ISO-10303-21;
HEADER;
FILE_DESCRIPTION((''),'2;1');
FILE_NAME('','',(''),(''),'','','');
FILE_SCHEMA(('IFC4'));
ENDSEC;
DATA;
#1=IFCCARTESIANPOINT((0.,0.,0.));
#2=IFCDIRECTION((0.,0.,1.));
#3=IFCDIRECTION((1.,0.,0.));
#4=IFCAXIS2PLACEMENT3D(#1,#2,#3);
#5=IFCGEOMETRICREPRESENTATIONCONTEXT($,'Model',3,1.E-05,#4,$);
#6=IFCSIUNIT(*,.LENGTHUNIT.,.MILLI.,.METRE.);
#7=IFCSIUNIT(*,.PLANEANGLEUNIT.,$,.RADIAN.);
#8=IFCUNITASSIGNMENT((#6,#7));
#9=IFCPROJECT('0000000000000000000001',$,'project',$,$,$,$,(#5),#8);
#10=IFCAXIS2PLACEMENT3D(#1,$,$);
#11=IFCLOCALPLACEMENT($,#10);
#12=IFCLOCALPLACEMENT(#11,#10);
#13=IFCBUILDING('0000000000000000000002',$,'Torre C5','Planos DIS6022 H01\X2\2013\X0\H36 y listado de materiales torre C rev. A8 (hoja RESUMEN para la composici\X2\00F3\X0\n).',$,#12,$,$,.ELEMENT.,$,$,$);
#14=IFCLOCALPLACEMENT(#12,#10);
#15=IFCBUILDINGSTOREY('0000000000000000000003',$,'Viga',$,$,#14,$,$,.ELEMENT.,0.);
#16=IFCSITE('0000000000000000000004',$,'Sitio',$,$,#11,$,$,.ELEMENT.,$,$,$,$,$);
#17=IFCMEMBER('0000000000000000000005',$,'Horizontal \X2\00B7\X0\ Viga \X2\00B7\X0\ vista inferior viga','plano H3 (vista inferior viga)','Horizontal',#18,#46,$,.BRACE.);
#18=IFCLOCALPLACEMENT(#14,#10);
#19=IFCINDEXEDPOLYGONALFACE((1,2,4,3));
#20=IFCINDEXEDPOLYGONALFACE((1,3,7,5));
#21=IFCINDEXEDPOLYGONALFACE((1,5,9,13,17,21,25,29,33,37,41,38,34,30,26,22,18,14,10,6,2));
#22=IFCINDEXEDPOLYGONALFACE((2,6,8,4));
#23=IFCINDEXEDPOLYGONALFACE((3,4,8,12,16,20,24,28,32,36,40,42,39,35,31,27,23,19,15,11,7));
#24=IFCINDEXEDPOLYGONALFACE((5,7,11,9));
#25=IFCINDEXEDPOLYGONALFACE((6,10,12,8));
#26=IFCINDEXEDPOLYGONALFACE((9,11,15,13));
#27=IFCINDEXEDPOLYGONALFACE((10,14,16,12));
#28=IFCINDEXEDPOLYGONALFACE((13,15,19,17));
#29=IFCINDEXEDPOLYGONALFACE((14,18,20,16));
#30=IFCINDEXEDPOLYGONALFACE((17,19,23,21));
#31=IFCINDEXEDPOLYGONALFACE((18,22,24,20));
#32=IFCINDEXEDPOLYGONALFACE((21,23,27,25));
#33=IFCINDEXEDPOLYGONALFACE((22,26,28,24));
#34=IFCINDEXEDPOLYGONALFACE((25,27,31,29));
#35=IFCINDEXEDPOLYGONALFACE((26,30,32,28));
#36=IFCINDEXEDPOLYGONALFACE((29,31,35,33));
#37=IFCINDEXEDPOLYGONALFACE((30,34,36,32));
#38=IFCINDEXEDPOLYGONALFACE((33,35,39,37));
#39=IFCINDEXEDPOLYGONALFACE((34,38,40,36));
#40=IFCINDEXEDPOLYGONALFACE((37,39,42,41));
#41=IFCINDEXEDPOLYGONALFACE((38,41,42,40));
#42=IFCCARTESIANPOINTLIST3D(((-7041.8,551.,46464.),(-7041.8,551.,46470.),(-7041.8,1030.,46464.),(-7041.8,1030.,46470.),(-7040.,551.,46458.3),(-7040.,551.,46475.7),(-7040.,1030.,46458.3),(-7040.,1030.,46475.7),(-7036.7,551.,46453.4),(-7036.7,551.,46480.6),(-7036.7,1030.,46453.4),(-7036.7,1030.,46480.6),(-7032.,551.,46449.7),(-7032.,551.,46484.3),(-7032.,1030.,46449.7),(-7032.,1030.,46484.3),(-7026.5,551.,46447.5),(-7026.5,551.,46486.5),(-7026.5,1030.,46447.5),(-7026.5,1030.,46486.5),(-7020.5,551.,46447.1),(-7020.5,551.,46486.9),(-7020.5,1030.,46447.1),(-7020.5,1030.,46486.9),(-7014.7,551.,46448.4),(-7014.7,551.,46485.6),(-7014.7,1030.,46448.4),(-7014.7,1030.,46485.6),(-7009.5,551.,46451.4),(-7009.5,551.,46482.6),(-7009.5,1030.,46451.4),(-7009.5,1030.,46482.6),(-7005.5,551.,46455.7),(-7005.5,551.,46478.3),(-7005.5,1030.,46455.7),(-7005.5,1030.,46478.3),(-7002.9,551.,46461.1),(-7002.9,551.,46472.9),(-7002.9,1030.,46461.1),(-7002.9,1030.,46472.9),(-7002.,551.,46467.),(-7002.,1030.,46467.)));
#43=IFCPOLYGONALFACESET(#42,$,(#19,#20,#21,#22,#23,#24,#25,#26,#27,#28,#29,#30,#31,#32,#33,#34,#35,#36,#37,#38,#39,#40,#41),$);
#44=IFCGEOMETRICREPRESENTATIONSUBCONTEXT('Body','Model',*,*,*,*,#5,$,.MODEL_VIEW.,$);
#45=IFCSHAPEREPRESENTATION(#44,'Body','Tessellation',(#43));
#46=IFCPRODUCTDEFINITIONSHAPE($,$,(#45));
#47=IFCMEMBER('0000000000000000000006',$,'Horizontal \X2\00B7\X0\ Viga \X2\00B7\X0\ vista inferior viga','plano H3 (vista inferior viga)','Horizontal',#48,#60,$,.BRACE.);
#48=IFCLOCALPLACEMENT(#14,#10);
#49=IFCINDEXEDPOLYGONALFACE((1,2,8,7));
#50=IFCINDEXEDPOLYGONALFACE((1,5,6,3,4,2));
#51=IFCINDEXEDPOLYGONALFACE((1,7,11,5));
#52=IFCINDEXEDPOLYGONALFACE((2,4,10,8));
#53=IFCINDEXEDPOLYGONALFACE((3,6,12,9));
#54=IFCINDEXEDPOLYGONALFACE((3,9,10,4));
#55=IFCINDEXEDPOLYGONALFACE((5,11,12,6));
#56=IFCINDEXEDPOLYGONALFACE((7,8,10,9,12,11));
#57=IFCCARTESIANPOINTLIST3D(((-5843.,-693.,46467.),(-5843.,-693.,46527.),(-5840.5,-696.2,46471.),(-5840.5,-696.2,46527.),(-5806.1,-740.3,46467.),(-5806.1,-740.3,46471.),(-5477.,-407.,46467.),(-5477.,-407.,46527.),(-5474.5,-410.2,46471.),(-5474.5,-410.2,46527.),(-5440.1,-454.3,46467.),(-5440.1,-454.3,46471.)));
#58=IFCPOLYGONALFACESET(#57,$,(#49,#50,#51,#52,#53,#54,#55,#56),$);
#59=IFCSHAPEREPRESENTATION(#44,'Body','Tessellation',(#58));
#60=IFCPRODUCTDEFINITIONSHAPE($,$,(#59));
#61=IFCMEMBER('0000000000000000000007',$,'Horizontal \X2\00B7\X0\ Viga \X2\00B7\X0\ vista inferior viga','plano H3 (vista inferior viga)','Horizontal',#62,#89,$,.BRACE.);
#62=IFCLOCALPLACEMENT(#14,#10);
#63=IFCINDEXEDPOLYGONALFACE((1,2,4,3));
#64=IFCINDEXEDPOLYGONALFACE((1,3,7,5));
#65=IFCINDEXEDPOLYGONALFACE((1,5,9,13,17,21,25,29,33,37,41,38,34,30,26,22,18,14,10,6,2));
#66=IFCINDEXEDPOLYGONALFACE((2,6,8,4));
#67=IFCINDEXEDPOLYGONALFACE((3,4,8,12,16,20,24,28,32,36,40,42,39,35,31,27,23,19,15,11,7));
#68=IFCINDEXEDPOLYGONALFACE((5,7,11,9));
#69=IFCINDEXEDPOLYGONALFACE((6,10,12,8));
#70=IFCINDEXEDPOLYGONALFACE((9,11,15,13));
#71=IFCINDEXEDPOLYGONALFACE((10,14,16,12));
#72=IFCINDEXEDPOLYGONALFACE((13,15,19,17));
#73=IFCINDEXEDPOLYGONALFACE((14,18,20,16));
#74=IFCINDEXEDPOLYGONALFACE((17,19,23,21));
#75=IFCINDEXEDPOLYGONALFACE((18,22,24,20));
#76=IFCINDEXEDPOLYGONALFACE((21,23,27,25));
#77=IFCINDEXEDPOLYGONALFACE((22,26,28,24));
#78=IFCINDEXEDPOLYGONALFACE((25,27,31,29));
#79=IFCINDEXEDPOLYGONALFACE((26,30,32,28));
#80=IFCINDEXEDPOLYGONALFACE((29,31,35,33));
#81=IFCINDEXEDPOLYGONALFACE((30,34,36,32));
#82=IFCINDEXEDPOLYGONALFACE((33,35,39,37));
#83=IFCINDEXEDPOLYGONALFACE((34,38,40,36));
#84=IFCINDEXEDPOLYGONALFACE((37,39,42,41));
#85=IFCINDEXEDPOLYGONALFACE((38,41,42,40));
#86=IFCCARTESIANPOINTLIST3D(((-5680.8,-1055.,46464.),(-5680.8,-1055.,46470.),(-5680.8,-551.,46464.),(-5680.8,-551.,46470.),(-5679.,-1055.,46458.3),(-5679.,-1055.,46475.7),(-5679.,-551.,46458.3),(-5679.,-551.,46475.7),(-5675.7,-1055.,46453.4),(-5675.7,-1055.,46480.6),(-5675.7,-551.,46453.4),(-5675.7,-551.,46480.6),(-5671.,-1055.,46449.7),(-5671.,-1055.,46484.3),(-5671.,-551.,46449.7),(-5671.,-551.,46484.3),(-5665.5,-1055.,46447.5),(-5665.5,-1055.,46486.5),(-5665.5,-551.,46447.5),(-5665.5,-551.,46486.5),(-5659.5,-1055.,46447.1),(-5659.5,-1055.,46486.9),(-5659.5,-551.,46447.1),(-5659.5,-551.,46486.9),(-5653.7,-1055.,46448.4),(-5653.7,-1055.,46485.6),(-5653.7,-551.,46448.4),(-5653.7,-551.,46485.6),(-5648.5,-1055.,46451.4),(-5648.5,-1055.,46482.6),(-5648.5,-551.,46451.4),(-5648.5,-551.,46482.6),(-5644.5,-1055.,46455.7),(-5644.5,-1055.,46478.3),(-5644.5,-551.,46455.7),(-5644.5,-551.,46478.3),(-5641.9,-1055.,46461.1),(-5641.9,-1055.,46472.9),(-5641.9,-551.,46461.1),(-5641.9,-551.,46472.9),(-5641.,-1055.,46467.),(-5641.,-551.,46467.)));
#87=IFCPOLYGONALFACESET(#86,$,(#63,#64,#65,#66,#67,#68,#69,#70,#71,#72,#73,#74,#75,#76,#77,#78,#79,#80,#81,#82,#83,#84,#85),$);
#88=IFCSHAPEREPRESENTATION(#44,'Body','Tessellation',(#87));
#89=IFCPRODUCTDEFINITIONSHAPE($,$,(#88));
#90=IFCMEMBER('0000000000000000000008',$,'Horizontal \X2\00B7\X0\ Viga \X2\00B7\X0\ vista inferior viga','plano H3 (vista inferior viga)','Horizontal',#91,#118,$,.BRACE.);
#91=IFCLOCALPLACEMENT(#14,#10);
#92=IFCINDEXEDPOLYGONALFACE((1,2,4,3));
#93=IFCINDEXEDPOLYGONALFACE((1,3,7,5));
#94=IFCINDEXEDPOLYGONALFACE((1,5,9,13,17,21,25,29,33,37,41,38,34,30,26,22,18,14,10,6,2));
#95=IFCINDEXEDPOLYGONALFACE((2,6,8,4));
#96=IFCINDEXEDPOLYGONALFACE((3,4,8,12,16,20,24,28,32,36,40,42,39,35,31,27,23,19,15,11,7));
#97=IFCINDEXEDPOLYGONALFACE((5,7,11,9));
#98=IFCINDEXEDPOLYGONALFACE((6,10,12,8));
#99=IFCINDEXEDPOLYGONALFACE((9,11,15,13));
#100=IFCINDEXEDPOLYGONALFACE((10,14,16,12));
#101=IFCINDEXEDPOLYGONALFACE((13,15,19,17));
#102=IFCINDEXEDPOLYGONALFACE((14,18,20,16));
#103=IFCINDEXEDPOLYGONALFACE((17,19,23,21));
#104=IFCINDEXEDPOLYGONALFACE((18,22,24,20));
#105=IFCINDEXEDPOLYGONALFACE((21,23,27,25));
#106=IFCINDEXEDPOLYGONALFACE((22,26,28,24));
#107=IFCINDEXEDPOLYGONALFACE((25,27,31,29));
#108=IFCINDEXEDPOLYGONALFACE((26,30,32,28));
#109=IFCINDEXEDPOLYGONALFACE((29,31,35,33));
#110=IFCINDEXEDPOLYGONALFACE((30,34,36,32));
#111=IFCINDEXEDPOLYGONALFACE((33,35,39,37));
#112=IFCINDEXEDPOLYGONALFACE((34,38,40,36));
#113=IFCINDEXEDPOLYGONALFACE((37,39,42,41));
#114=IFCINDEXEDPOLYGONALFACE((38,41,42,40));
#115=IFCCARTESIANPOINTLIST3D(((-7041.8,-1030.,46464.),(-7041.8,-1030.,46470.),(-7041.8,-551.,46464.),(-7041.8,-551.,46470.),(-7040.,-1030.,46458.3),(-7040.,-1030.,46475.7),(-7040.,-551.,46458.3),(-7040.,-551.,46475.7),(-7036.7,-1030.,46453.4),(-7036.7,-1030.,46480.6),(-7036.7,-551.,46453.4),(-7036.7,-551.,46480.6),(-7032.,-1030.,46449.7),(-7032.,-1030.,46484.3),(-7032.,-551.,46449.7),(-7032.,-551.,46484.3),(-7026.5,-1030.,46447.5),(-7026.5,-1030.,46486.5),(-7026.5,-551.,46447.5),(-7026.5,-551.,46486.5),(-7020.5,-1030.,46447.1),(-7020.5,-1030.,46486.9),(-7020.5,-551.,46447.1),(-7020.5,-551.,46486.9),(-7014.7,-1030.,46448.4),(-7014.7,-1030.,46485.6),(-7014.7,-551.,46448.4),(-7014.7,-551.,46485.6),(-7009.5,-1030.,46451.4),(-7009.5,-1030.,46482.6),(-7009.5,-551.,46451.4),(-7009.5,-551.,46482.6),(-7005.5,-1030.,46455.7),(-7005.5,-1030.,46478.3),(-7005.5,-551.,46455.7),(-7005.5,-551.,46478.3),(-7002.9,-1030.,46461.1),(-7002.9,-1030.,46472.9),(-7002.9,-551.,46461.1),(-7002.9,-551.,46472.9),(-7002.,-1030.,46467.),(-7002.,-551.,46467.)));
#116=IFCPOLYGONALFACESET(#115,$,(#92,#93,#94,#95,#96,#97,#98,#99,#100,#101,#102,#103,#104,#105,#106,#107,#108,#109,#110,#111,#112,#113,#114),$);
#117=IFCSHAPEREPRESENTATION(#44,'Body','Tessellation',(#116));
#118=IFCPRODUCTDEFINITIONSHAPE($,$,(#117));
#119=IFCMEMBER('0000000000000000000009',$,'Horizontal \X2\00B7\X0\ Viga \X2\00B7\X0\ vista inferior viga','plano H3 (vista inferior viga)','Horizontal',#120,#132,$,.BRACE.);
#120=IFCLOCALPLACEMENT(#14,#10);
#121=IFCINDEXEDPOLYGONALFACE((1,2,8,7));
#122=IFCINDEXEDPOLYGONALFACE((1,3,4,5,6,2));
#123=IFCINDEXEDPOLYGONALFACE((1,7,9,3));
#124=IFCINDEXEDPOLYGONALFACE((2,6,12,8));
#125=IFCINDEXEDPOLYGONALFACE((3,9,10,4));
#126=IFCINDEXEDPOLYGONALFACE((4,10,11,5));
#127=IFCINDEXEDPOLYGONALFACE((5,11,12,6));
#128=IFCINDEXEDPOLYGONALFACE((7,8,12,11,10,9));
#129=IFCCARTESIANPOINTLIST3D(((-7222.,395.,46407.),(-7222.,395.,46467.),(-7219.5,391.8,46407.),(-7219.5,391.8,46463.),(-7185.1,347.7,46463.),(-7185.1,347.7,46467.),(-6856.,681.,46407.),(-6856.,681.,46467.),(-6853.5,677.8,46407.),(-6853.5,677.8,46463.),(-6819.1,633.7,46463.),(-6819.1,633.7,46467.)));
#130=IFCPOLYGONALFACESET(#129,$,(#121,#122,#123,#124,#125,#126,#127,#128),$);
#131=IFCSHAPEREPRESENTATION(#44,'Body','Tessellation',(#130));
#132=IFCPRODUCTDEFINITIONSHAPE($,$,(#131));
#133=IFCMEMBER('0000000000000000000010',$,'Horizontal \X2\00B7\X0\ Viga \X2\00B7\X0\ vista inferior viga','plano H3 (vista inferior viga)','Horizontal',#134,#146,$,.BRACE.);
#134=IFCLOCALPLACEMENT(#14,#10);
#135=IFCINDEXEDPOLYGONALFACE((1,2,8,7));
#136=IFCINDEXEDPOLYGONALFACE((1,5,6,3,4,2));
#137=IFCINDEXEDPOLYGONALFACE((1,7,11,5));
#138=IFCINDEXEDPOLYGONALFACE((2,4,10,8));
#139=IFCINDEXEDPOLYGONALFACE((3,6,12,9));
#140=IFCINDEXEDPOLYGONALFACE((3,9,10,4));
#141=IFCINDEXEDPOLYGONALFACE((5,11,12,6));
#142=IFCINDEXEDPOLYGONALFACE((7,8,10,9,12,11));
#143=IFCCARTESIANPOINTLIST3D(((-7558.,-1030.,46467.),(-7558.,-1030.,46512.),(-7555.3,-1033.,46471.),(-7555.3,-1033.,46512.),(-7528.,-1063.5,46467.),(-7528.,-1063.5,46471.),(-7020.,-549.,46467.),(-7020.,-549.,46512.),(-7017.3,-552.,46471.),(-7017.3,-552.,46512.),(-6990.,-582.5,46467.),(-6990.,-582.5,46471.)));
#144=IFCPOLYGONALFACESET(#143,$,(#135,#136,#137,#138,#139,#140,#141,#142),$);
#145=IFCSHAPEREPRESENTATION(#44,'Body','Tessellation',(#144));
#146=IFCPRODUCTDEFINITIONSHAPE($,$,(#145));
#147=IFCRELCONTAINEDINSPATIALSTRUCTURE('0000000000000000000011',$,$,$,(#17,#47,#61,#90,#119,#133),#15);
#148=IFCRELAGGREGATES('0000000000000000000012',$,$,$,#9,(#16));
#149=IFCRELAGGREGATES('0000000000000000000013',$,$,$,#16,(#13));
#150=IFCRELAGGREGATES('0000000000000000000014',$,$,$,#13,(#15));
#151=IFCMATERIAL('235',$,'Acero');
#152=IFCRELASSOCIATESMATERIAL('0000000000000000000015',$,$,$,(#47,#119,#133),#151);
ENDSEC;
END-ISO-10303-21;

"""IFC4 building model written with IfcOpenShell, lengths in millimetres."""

from ifc_helpers import new_model, si_unit, frame, frame_2d, origin, origin_with_axes, place, context, subcontext, project, spatial, circle, l_section, extrude, material, element, save


model = new_model("IFC4")

# Units and contexts
model_context = context("Model", 3, precision=1e-05, world=origin_with_axes())
body_context = subcontext(model_context, "Body", "Model", "MODEL_VIEW")
ifc_project = project(units=[si_unit("LENGTHUNIT", "METRE", prefix="MILLI"), si_unit("PLANEANGLEUNIT", "RADIAN")], contexts=[model_context])

# Site, building, storey
site_placement = place(None, origin())
site = spatial("IfcSite", under=ifc_project, at=site_placement, Name="Sitio", CompositionType="ELEMENT")
building_placement = place(site_placement, origin())
building = spatial("IfcBuilding", under=site, at=building_placement, Name="Torre C5", Description="Planos DIS6022 H01–H36 y listado de materiales torre C rev. A8 (hoja RESUMEN para la composición).", CompositionType="ELEMENT")
storey_placement = place(building_placement, origin())
storey = spatial("IfcBuildingStorey", under=building, at=storey_placement, Name="Viga", CompositionType="ELEMENT", Elevation=0.0)

# Members
ifc_material_1 = material(Name="235", Category="Acero")
member_1_placement = place(storey_placement, frame((-7022.0, 551.0, 46467.0), z_axis=(0.0, 1.0, 0.0), x_axis=(1.0, 0.0, 0.0)))
element("IfcMember", 1, at=member_1_placement, inside=storey, Name="Horizontal · Viga · vista inferior viga", Description="plano H3 (vista inferior viga)", ObjectType="Horizontal", PredefinedType="BRACE", context=body_context, shape_type="SweptSolid", body=[
    extrude(circle(Radius=20.0), None, (0.0, 0.0, 1.0), 479.0),
])
member_2_placement = place(storey_placement, frame((-5477.0, -407.0, 46467.0), z_axis=(-0.787959, -0.615728, 0.0), x_axis=(0.615728, -0.787959, 0.0)))
element("IfcMember", 2, at=member_2_placement, inside=storey, material=ifc_material_1, Name="Horizontal · Viga · vista inferior viga", Description="plano H3 (vista inferior viga)", ObjectType="Horizontal", PredefinedType="BRACE", context=body_context, shape_type="SweptSolid", body=[
    extrude(l_section(Depth=60.0, Width=60.0, Thickness=4.0, at=frame_2d((30.0, 30.0))), None, (0.0, 0.0, 1.0), 464.5),
])
member_3_placement = place(storey_placement, frame((-5661.0, -551.0, 46467.0), z_axis=(0.0, -1.0, 0.0), x_axis=(1.0, 0.0, 0.0)))
element("IfcMember", 3, at=member_3_placement, inside=storey, Name="Horizontal · Viga · vista inferior viga", Description="plano H3 (vista inferior viga)", ObjectType="Horizontal", PredefinedType="BRACE", context=body_context, shape_type="SweptSolid", body=[
    extrude(circle(Radius=20.0), None, (0.0, 0.0, 1.0), 504.0),
])
member_4_placement = place(storey_placement, frame((-7022.0, -551.0, 46467.0), z_axis=(0.0, -1.0, 0.0), x_axis=(1.0, 0.0, 0.0)))
element("IfcMember", 4, at=member_4_placement, inside=storey, Name="Horizontal · Viga · vista inferior viga", Description="plano H3 (vista inferior viga)", ObjectType="Horizontal", PredefinedType="BRACE", context=body_context, shape_type="SweptSolid", body=[
    extrude(circle(Radius=20.0), None, (0.0, 0.0, 1.0), 479.0),
])
member_5_placement = place(storey_placement, frame((-7222.0, 395.0, 46467.0), z_axis=(0.787959, 0.615728, 0.0), x_axis=(0.615728, -0.787959, 0.0)))
element("IfcMember", 5, at=member_5_placement, inside=storey, material=ifc_material_1, Name="Horizontal · Viga · vista inferior viga", Description="plano H3 (vista inferior viga)", ObjectType="Horizontal", PredefinedType="BRACE", context=body_context, shape_type="SweptSolid", body=[
    extrude(l_section(Depth=60.0, Width=60.0, Thickness=4.0, at=frame_2d((30.0, 30.0))), None, (0.0, 0.0, 1.0), 464.5),
])
member_6_placement = place(storey_placement, frame((-7020.0, -549.0, 46467.0), z_axis=(-0.745495, -0.666511, 0.0), x_axis=(0.666511, -0.745495, 0.0)))
element("IfcMember", 6, at=member_6_placement, inside=storey, material=ifc_material_1, Name="Horizontal · Viga · vista inferior viga", Description="plano H3 (vista inferior viga)", ObjectType="Horizontal", PredefinedType="BRACE", context=body_context, shape_type="SweptSolid", body=[
    extrude(l_section(Depth=45.0, Width=45.0, Thickness=4.0, at=frame_2d((22.5, 22.5))), None, (0.0, 0.0, 1.0), 721.7),
])

save(model, "model.ifc")
